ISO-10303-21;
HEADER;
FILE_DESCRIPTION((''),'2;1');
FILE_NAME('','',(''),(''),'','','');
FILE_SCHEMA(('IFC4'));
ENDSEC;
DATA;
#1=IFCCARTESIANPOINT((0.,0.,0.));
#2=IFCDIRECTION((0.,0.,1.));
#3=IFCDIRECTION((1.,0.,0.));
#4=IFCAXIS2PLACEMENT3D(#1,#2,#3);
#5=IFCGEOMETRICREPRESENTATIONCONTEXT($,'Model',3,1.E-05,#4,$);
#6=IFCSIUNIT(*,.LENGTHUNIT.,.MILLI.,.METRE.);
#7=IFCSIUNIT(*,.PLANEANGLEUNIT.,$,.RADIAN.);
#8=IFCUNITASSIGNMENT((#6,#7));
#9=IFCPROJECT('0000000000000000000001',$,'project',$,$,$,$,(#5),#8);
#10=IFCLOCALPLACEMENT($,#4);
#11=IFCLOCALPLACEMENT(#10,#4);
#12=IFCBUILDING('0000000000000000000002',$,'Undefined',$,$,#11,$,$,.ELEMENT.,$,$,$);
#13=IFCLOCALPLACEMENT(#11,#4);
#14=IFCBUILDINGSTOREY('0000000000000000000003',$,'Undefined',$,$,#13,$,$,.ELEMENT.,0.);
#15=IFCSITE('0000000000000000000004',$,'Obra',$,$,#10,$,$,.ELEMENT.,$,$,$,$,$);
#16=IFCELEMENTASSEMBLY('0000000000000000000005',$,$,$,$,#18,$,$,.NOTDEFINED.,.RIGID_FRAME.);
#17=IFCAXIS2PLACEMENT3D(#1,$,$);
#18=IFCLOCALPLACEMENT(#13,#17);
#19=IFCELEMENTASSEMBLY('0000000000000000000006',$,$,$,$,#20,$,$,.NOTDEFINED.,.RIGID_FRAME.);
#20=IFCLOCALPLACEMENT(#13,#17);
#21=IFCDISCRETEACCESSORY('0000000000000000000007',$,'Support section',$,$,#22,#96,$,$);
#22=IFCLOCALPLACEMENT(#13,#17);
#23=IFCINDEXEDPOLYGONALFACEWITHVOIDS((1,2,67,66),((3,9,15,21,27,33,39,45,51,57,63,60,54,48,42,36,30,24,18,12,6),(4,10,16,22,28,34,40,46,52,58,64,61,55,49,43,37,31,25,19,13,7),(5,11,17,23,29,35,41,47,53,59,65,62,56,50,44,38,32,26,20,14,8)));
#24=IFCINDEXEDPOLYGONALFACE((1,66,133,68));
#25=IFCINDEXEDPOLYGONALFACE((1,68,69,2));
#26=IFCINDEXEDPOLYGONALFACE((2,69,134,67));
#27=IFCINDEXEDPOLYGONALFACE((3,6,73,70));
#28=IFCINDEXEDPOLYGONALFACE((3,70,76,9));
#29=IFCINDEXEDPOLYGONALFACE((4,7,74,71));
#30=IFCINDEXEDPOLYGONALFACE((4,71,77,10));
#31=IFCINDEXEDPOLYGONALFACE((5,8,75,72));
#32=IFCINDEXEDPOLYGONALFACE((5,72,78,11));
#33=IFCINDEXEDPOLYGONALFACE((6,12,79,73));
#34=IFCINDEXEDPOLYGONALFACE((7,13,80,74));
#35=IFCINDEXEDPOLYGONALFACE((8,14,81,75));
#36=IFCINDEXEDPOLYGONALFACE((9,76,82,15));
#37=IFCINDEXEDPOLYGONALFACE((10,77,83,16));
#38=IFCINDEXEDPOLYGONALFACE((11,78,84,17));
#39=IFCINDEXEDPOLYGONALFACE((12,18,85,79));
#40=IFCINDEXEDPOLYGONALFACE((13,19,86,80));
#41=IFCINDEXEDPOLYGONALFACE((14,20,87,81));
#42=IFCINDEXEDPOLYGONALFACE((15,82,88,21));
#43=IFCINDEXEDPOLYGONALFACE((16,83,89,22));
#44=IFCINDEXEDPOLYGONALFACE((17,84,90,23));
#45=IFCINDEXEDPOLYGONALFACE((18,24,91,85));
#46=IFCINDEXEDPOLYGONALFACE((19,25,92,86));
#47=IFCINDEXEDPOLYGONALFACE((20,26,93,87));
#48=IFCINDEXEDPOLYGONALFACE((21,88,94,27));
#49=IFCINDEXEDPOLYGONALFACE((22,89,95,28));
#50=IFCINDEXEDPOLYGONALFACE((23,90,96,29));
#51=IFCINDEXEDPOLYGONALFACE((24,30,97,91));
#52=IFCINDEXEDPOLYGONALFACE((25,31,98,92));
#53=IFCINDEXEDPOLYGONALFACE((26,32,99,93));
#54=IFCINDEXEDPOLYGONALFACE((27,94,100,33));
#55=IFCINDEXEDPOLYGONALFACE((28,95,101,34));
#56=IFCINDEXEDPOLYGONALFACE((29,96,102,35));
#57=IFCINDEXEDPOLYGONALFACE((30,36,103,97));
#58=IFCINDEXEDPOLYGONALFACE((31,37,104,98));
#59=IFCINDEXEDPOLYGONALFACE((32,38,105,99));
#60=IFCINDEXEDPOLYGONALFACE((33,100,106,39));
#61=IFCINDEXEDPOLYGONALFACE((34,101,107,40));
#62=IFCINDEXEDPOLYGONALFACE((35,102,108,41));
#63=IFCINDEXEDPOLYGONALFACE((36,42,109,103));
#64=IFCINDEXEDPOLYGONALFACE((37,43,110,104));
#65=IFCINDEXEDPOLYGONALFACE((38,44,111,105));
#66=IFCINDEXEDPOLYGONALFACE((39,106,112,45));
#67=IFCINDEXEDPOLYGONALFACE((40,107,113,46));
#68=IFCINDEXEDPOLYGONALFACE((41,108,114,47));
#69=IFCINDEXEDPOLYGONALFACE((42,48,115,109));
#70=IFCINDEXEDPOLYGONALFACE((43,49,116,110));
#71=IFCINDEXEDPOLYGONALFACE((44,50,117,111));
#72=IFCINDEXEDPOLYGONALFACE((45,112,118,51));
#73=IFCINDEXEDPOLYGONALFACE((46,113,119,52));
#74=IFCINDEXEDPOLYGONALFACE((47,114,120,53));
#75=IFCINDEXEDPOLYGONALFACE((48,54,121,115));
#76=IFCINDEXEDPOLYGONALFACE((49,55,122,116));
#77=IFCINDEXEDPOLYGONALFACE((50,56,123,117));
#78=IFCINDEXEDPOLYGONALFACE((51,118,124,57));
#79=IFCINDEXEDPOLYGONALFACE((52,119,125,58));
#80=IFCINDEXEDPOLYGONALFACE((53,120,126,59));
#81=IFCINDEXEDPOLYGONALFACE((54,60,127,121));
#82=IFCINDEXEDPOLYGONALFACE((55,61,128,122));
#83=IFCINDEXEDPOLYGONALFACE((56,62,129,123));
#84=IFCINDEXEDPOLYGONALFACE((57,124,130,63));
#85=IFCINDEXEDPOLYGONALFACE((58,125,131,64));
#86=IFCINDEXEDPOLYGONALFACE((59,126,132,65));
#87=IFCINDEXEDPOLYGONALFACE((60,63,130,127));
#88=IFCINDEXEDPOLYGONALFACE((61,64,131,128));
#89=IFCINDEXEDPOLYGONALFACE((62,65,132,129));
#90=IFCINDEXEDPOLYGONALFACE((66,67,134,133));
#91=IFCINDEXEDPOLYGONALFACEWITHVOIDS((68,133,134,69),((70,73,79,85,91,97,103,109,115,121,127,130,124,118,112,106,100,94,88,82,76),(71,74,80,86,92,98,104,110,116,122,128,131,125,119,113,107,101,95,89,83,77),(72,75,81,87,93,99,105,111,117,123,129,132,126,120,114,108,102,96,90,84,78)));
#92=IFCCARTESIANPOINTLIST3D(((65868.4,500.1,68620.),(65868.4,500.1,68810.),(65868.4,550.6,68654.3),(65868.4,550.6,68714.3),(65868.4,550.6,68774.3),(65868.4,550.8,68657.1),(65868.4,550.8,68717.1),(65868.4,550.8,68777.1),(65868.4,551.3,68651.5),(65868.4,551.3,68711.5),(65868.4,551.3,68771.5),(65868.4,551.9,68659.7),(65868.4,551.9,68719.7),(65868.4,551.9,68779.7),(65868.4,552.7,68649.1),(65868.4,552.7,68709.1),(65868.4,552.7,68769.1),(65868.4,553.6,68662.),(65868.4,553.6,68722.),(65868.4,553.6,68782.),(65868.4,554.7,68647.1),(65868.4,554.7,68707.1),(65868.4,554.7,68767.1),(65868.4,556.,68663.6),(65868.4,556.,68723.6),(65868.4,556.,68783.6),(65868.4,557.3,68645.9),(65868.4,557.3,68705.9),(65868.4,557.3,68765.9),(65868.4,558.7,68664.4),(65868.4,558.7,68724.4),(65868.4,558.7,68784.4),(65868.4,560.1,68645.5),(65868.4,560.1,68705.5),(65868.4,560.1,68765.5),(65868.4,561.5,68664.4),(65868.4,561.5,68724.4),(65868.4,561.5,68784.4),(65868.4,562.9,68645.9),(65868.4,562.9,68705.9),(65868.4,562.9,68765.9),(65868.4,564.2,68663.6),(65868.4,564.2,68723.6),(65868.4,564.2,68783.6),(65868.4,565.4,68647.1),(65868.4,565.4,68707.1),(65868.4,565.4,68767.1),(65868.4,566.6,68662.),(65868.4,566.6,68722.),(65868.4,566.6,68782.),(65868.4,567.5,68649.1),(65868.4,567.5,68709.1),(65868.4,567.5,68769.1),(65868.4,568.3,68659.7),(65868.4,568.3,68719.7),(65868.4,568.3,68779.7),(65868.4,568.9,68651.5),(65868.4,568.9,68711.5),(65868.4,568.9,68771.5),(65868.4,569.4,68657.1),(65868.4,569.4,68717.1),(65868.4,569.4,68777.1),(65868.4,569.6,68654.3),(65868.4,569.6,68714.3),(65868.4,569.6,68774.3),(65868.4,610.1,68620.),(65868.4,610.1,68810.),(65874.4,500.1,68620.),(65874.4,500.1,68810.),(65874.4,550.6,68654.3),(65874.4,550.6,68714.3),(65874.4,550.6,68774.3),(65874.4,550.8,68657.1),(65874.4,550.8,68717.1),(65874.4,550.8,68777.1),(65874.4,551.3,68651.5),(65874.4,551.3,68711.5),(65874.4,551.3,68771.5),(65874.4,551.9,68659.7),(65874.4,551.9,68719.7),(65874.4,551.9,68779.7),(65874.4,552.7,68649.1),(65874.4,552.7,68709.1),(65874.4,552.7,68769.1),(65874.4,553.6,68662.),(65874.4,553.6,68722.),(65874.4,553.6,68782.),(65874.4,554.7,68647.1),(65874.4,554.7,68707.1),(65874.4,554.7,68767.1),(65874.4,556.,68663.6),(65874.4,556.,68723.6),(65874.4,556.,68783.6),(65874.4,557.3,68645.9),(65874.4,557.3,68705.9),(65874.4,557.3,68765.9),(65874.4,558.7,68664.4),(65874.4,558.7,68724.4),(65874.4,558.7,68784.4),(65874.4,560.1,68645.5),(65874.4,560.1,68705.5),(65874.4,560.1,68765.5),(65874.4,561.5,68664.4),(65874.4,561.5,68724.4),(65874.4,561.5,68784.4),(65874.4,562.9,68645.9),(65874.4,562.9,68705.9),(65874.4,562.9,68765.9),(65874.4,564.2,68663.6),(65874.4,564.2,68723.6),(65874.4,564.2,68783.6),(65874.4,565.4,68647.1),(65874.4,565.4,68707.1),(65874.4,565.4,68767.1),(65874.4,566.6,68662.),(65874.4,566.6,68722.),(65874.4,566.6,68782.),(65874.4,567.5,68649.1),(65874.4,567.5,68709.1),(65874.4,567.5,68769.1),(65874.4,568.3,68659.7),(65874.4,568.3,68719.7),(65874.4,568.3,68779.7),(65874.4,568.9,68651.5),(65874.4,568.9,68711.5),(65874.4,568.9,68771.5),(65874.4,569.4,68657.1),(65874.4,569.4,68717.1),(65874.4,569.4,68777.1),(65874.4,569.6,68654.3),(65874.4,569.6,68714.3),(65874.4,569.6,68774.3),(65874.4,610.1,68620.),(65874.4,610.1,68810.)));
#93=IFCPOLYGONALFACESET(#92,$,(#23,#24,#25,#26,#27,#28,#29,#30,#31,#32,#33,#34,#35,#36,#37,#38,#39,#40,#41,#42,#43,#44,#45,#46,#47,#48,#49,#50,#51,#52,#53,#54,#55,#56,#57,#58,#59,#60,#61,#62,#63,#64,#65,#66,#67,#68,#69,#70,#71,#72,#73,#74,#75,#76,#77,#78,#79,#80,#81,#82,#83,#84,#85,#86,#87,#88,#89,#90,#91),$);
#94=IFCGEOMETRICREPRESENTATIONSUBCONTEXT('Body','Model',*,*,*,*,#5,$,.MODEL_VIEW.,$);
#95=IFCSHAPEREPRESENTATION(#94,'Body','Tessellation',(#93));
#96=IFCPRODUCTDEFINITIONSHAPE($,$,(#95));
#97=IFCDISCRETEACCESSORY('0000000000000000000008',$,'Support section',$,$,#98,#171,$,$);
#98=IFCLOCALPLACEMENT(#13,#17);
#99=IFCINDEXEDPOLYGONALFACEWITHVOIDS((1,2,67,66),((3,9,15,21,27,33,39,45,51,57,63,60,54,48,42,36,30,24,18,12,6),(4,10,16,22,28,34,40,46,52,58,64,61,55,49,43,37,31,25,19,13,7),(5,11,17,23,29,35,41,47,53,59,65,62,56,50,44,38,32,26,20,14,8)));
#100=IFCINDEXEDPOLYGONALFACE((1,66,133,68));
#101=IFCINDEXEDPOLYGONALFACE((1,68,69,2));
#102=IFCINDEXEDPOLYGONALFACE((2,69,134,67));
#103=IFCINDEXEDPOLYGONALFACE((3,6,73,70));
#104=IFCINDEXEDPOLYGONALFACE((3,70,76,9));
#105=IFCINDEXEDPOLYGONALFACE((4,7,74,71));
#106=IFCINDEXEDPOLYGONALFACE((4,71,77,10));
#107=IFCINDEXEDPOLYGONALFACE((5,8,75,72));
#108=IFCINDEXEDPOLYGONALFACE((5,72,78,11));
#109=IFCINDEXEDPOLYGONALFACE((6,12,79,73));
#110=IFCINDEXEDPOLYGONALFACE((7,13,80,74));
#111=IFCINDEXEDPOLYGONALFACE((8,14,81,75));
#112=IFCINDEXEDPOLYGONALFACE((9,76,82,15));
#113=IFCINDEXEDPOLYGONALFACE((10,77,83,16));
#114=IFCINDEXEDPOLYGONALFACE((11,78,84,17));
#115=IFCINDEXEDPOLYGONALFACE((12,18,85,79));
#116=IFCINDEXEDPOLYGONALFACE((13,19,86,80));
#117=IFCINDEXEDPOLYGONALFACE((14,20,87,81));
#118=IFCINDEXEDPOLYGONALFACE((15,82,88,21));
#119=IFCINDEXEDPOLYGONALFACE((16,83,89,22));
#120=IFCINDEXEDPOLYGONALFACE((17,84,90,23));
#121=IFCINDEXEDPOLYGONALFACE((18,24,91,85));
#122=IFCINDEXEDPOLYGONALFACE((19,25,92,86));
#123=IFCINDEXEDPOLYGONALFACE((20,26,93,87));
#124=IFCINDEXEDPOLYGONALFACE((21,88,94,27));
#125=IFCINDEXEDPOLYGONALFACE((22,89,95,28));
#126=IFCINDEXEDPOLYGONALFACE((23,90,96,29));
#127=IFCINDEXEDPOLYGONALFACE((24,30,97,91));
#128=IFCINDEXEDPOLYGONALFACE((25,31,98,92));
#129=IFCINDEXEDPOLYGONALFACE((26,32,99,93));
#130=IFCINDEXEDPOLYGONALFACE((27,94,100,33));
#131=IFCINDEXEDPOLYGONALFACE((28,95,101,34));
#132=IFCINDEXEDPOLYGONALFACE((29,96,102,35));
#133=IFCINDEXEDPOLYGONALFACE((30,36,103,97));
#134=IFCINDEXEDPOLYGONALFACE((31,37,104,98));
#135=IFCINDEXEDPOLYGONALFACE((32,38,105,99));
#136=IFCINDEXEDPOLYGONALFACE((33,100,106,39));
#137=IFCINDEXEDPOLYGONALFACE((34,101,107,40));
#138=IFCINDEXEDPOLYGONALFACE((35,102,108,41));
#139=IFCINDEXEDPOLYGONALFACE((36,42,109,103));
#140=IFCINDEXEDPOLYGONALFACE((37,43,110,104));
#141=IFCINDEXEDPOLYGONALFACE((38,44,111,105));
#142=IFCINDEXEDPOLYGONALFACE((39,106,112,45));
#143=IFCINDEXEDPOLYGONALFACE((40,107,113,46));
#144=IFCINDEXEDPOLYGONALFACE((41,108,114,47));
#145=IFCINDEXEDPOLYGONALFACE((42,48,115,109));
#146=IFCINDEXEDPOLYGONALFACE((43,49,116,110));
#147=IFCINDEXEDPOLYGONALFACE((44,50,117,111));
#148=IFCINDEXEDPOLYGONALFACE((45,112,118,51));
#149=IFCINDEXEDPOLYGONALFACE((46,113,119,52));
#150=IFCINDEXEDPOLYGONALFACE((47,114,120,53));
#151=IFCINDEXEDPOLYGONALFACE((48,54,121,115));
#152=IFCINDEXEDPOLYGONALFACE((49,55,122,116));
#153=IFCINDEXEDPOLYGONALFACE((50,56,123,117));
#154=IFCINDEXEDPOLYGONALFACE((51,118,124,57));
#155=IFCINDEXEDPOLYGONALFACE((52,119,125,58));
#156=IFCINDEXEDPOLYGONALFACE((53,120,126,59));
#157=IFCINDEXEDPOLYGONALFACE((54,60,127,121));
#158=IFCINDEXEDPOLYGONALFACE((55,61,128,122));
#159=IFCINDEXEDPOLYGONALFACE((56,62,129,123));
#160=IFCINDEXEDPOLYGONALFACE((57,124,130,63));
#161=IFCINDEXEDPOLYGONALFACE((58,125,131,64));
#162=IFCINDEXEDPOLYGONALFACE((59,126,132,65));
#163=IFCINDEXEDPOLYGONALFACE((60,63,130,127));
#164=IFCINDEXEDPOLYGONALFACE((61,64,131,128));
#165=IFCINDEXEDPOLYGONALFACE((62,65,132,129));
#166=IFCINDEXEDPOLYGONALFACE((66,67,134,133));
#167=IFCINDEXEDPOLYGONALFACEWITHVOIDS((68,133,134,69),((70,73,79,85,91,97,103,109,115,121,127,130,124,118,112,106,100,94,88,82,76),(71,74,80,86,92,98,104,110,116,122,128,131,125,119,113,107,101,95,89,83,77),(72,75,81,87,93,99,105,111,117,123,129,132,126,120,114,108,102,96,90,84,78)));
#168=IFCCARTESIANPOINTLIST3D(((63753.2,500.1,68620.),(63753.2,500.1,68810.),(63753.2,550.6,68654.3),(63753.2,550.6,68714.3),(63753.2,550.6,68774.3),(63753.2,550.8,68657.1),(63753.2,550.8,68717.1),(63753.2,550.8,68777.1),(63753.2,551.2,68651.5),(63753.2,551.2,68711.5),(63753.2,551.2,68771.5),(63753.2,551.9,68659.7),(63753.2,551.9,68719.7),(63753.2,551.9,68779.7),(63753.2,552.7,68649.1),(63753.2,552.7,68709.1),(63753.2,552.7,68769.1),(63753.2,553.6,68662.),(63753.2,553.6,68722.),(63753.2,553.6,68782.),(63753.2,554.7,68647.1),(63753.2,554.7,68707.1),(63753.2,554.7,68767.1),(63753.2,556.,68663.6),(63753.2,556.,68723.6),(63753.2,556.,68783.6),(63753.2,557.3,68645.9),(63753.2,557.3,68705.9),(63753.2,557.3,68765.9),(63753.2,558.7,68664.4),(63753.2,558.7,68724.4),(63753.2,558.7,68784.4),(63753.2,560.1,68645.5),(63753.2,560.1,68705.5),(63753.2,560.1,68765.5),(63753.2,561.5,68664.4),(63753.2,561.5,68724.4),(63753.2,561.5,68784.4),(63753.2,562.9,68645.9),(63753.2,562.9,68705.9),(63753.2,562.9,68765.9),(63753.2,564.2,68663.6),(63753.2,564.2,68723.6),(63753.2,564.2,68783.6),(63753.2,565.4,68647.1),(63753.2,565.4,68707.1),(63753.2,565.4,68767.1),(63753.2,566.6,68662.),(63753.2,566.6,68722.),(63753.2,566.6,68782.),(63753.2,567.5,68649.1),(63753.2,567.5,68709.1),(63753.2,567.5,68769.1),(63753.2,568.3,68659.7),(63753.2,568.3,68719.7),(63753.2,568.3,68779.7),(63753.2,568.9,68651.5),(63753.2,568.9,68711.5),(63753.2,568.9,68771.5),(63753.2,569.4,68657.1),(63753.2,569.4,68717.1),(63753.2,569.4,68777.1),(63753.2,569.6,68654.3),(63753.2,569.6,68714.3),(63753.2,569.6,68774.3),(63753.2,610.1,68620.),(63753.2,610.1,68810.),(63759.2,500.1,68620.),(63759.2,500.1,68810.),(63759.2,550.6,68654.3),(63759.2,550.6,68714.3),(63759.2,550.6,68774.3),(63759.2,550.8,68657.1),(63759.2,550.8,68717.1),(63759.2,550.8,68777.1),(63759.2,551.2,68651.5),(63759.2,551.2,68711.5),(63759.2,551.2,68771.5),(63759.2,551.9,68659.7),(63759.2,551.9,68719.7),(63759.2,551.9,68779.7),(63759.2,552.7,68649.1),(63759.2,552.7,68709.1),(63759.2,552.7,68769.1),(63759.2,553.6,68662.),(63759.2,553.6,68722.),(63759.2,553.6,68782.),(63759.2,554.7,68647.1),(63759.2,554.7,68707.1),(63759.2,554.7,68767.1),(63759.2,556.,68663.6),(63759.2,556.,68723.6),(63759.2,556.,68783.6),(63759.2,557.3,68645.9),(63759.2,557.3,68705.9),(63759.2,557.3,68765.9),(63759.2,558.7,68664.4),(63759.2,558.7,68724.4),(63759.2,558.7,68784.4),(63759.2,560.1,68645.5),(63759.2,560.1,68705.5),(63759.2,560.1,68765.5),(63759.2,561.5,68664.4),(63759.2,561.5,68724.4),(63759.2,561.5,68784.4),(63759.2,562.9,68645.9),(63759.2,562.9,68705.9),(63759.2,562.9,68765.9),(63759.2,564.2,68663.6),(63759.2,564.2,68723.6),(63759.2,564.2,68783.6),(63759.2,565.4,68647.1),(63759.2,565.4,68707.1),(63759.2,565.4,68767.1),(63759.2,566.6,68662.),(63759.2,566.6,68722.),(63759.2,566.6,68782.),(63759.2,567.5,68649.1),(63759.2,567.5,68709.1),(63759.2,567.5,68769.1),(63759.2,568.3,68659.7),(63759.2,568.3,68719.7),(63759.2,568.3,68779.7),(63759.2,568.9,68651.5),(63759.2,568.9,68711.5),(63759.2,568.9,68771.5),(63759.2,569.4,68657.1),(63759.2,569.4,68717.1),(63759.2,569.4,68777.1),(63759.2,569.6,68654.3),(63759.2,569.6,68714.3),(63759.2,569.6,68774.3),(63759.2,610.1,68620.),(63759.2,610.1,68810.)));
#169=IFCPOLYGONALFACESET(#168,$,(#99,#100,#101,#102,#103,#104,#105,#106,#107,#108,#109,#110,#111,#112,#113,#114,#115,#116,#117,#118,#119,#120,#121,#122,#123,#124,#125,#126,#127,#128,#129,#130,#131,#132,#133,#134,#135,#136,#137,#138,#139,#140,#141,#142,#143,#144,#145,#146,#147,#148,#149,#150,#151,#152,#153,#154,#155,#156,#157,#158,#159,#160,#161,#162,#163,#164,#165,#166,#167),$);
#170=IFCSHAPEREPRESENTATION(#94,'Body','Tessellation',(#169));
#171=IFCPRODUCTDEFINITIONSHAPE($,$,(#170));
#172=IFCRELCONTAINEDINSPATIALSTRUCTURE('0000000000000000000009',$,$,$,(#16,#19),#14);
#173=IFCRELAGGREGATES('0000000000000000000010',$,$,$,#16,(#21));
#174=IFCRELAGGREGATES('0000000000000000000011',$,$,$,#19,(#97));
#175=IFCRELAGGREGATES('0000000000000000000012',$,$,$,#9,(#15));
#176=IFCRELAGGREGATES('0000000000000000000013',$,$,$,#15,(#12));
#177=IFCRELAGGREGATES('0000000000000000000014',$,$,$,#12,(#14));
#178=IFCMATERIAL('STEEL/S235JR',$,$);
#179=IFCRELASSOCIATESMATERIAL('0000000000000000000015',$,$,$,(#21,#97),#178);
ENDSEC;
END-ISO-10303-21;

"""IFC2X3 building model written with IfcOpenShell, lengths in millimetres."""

from ifc_helpers import new_model, si_unit, frame, origin_with_axes, origin_2d_with_axis, place, context, subcontext, project, spatial, rectangle, circle, extrude, source, transform, mapped, material, element, aggregate, save


model = new_model("IFC2X3")

# Units and contexts
model_context = context("Model", 3, precision=1e-05, world=origin_with_axes())
body_context = subcontext(model_context, "Body", "Model", "MODEL_VIEW")
ifc_project = project(units=[si_unit("LENGTHUNIT", "METRE", prefix="MILLI"), si_unit("PLANEANGLEUNIT", "RADIAN")], contexts=[model_context])

# Site, building, storey
site_placement = place(None, origin_with_axes())
site = spatial("IfcSite", under=ifc_project, at=site_placement, Name="Obra", CompositionType="ELEMENT")
building_placement = place(site_placement, origin_with_axes())
building = spatial("IfcBuilding", under=site, at=building_placement, Name="Undefined", CompositionType="ELEMENT")
storey_placement = place(building_placement, origin_with_axes())
storey = spatial("IfcBuildingStorey", under=building, at=storey_placement, Name="Undefined", CompositionType="ELEMENT", Elevation=0.0)

# Element assemblies
assembly_1_placement = place(storey_placement, origin_with_axes())
assembly_1 = element("IfcElementAssembly", 1, at=assembly_1_placement, inside=storey, AssemblyPlace="NOTDEFINED", PredefinedType="RIGID_FRAME")
ifc_material = material(Name="STEEL/S235JR")
assembly_2_placement = place(storey_placement, origin_with_axes())
assembly_2 = element("IfcElementAssembly", 2, at=assembly_2_placement, inside=storey, AssemblyPlace="NOTDEFINED", PredefinedType="RIGID_FRAME")

# Discrete accessories, openings
discrete_accessory_1_placement = place(assembly_1_placement, frame((65871.4, 555.1, 68620.0), z_axis=(0.0, 0.0, 1.0), x_axis=(0.000002, -1.0, 0.0)))
discrete_accessory_1 = element("IfcDiscreteAccessory", 3, at=discrete_accessory_1_placement, material=ifc_material, Name="Support section", context=body_context, shape_type="SweptSolid", body=[
    extrude(rectangle(XDim=6.0, YDim=110.0, at=origin_2d_with_axis()), frame((0.0, 0.0, 190.0), z_axis=(0.0, 0.0, -1.0), x_axis=(0.0, 1.0, 0.0)), (0.0, 0.0, 1.0), 190.0),
])
shared_shape_1 = source(origin_with_axes(), body_context, "Body", "SweptSolid", [
    extrude(circle(Radius=9.5, at=origin_2d_with_axis()), frame((0.0, -9.2, 0.0), z_axis=(0.0, 1.0, 0.0), x_axis=(1.0, 0.0, 0.0)), (0.0, 0.0, 1.0), 6.2),
])
opening_1_placement = place(assembly_1_placement, frame((65865.3, 510.1, 68835.0), z_axis=(-0.000002, 1.0, 0.0), x_axis=(0.0, 0.0, -1.0)))
element("IfcOpeningElement", 4, at=opening_1_placement, cuts=discrete_accessory_1, ObjectType="Opening", context=body_context, shape_type="MappedRepresentation", body=[
    mapped(shared_shape_1, transform((60.0, 0.0, 50.0))),
    mapped(shared_shape_1, transform((120.0, 0.0, 50.0))),
    mapped(shared_shape_1, transform((180.0, 0.0, 50.0))),
])
aggregate(assembly_1, [discrete_accessory_1])
discrete_accessory_2_placement = place(assembly_2_placement, frame((63756.2, 555.1, 68620.0), z_axis=(0.0, 0.0, 1.0), x_axis=(0.000002, -1.0, 0.0)))
discrete_accessory_2 = element("IfcDiscreteAccessory", 5, at=discrete_accessory_2_placement, material=ifc_material, Name="Support section", context=body_context, shape_type="SweptSolid", body=[
    extrude(rectangle(XDim=6.0, YDim=110.0, at=origin_2d_with_axis()), frame((0.0, 0.0, 190.0), z_axis=(0.0, 0.0, -1.0), x_axis=(0.0, 1.0, 0.0)), (0.0, 0.0, 1.0), 190.0),
])
opening_2_placement = place(assembly_2_placement, frame((63750.1, 510.1, 68835.0), z_axis=(-0.000002, 1.0, 0.0), x_axis=(0.0, 0.0, -1.0)))
element("IfcOpeningElement", 6, at=opening_2_placement, cuts=discrete_accessory_2, ObjectType="Opening", context=body_context, shape_type="MappedRepresentation", body=[
    mapped(shared_shape_1, transform((60.0, 0.0, 50.0))),
    mapped(shared_shape_1, transform((120.0, 0.0, 50.0))),
    mapped(shared_shape_1, transform((180.0, 0.0, 50.0))),
])
aggregate(assembly_2, [discrete_accessory_2])

save(model, "model.ifc")
